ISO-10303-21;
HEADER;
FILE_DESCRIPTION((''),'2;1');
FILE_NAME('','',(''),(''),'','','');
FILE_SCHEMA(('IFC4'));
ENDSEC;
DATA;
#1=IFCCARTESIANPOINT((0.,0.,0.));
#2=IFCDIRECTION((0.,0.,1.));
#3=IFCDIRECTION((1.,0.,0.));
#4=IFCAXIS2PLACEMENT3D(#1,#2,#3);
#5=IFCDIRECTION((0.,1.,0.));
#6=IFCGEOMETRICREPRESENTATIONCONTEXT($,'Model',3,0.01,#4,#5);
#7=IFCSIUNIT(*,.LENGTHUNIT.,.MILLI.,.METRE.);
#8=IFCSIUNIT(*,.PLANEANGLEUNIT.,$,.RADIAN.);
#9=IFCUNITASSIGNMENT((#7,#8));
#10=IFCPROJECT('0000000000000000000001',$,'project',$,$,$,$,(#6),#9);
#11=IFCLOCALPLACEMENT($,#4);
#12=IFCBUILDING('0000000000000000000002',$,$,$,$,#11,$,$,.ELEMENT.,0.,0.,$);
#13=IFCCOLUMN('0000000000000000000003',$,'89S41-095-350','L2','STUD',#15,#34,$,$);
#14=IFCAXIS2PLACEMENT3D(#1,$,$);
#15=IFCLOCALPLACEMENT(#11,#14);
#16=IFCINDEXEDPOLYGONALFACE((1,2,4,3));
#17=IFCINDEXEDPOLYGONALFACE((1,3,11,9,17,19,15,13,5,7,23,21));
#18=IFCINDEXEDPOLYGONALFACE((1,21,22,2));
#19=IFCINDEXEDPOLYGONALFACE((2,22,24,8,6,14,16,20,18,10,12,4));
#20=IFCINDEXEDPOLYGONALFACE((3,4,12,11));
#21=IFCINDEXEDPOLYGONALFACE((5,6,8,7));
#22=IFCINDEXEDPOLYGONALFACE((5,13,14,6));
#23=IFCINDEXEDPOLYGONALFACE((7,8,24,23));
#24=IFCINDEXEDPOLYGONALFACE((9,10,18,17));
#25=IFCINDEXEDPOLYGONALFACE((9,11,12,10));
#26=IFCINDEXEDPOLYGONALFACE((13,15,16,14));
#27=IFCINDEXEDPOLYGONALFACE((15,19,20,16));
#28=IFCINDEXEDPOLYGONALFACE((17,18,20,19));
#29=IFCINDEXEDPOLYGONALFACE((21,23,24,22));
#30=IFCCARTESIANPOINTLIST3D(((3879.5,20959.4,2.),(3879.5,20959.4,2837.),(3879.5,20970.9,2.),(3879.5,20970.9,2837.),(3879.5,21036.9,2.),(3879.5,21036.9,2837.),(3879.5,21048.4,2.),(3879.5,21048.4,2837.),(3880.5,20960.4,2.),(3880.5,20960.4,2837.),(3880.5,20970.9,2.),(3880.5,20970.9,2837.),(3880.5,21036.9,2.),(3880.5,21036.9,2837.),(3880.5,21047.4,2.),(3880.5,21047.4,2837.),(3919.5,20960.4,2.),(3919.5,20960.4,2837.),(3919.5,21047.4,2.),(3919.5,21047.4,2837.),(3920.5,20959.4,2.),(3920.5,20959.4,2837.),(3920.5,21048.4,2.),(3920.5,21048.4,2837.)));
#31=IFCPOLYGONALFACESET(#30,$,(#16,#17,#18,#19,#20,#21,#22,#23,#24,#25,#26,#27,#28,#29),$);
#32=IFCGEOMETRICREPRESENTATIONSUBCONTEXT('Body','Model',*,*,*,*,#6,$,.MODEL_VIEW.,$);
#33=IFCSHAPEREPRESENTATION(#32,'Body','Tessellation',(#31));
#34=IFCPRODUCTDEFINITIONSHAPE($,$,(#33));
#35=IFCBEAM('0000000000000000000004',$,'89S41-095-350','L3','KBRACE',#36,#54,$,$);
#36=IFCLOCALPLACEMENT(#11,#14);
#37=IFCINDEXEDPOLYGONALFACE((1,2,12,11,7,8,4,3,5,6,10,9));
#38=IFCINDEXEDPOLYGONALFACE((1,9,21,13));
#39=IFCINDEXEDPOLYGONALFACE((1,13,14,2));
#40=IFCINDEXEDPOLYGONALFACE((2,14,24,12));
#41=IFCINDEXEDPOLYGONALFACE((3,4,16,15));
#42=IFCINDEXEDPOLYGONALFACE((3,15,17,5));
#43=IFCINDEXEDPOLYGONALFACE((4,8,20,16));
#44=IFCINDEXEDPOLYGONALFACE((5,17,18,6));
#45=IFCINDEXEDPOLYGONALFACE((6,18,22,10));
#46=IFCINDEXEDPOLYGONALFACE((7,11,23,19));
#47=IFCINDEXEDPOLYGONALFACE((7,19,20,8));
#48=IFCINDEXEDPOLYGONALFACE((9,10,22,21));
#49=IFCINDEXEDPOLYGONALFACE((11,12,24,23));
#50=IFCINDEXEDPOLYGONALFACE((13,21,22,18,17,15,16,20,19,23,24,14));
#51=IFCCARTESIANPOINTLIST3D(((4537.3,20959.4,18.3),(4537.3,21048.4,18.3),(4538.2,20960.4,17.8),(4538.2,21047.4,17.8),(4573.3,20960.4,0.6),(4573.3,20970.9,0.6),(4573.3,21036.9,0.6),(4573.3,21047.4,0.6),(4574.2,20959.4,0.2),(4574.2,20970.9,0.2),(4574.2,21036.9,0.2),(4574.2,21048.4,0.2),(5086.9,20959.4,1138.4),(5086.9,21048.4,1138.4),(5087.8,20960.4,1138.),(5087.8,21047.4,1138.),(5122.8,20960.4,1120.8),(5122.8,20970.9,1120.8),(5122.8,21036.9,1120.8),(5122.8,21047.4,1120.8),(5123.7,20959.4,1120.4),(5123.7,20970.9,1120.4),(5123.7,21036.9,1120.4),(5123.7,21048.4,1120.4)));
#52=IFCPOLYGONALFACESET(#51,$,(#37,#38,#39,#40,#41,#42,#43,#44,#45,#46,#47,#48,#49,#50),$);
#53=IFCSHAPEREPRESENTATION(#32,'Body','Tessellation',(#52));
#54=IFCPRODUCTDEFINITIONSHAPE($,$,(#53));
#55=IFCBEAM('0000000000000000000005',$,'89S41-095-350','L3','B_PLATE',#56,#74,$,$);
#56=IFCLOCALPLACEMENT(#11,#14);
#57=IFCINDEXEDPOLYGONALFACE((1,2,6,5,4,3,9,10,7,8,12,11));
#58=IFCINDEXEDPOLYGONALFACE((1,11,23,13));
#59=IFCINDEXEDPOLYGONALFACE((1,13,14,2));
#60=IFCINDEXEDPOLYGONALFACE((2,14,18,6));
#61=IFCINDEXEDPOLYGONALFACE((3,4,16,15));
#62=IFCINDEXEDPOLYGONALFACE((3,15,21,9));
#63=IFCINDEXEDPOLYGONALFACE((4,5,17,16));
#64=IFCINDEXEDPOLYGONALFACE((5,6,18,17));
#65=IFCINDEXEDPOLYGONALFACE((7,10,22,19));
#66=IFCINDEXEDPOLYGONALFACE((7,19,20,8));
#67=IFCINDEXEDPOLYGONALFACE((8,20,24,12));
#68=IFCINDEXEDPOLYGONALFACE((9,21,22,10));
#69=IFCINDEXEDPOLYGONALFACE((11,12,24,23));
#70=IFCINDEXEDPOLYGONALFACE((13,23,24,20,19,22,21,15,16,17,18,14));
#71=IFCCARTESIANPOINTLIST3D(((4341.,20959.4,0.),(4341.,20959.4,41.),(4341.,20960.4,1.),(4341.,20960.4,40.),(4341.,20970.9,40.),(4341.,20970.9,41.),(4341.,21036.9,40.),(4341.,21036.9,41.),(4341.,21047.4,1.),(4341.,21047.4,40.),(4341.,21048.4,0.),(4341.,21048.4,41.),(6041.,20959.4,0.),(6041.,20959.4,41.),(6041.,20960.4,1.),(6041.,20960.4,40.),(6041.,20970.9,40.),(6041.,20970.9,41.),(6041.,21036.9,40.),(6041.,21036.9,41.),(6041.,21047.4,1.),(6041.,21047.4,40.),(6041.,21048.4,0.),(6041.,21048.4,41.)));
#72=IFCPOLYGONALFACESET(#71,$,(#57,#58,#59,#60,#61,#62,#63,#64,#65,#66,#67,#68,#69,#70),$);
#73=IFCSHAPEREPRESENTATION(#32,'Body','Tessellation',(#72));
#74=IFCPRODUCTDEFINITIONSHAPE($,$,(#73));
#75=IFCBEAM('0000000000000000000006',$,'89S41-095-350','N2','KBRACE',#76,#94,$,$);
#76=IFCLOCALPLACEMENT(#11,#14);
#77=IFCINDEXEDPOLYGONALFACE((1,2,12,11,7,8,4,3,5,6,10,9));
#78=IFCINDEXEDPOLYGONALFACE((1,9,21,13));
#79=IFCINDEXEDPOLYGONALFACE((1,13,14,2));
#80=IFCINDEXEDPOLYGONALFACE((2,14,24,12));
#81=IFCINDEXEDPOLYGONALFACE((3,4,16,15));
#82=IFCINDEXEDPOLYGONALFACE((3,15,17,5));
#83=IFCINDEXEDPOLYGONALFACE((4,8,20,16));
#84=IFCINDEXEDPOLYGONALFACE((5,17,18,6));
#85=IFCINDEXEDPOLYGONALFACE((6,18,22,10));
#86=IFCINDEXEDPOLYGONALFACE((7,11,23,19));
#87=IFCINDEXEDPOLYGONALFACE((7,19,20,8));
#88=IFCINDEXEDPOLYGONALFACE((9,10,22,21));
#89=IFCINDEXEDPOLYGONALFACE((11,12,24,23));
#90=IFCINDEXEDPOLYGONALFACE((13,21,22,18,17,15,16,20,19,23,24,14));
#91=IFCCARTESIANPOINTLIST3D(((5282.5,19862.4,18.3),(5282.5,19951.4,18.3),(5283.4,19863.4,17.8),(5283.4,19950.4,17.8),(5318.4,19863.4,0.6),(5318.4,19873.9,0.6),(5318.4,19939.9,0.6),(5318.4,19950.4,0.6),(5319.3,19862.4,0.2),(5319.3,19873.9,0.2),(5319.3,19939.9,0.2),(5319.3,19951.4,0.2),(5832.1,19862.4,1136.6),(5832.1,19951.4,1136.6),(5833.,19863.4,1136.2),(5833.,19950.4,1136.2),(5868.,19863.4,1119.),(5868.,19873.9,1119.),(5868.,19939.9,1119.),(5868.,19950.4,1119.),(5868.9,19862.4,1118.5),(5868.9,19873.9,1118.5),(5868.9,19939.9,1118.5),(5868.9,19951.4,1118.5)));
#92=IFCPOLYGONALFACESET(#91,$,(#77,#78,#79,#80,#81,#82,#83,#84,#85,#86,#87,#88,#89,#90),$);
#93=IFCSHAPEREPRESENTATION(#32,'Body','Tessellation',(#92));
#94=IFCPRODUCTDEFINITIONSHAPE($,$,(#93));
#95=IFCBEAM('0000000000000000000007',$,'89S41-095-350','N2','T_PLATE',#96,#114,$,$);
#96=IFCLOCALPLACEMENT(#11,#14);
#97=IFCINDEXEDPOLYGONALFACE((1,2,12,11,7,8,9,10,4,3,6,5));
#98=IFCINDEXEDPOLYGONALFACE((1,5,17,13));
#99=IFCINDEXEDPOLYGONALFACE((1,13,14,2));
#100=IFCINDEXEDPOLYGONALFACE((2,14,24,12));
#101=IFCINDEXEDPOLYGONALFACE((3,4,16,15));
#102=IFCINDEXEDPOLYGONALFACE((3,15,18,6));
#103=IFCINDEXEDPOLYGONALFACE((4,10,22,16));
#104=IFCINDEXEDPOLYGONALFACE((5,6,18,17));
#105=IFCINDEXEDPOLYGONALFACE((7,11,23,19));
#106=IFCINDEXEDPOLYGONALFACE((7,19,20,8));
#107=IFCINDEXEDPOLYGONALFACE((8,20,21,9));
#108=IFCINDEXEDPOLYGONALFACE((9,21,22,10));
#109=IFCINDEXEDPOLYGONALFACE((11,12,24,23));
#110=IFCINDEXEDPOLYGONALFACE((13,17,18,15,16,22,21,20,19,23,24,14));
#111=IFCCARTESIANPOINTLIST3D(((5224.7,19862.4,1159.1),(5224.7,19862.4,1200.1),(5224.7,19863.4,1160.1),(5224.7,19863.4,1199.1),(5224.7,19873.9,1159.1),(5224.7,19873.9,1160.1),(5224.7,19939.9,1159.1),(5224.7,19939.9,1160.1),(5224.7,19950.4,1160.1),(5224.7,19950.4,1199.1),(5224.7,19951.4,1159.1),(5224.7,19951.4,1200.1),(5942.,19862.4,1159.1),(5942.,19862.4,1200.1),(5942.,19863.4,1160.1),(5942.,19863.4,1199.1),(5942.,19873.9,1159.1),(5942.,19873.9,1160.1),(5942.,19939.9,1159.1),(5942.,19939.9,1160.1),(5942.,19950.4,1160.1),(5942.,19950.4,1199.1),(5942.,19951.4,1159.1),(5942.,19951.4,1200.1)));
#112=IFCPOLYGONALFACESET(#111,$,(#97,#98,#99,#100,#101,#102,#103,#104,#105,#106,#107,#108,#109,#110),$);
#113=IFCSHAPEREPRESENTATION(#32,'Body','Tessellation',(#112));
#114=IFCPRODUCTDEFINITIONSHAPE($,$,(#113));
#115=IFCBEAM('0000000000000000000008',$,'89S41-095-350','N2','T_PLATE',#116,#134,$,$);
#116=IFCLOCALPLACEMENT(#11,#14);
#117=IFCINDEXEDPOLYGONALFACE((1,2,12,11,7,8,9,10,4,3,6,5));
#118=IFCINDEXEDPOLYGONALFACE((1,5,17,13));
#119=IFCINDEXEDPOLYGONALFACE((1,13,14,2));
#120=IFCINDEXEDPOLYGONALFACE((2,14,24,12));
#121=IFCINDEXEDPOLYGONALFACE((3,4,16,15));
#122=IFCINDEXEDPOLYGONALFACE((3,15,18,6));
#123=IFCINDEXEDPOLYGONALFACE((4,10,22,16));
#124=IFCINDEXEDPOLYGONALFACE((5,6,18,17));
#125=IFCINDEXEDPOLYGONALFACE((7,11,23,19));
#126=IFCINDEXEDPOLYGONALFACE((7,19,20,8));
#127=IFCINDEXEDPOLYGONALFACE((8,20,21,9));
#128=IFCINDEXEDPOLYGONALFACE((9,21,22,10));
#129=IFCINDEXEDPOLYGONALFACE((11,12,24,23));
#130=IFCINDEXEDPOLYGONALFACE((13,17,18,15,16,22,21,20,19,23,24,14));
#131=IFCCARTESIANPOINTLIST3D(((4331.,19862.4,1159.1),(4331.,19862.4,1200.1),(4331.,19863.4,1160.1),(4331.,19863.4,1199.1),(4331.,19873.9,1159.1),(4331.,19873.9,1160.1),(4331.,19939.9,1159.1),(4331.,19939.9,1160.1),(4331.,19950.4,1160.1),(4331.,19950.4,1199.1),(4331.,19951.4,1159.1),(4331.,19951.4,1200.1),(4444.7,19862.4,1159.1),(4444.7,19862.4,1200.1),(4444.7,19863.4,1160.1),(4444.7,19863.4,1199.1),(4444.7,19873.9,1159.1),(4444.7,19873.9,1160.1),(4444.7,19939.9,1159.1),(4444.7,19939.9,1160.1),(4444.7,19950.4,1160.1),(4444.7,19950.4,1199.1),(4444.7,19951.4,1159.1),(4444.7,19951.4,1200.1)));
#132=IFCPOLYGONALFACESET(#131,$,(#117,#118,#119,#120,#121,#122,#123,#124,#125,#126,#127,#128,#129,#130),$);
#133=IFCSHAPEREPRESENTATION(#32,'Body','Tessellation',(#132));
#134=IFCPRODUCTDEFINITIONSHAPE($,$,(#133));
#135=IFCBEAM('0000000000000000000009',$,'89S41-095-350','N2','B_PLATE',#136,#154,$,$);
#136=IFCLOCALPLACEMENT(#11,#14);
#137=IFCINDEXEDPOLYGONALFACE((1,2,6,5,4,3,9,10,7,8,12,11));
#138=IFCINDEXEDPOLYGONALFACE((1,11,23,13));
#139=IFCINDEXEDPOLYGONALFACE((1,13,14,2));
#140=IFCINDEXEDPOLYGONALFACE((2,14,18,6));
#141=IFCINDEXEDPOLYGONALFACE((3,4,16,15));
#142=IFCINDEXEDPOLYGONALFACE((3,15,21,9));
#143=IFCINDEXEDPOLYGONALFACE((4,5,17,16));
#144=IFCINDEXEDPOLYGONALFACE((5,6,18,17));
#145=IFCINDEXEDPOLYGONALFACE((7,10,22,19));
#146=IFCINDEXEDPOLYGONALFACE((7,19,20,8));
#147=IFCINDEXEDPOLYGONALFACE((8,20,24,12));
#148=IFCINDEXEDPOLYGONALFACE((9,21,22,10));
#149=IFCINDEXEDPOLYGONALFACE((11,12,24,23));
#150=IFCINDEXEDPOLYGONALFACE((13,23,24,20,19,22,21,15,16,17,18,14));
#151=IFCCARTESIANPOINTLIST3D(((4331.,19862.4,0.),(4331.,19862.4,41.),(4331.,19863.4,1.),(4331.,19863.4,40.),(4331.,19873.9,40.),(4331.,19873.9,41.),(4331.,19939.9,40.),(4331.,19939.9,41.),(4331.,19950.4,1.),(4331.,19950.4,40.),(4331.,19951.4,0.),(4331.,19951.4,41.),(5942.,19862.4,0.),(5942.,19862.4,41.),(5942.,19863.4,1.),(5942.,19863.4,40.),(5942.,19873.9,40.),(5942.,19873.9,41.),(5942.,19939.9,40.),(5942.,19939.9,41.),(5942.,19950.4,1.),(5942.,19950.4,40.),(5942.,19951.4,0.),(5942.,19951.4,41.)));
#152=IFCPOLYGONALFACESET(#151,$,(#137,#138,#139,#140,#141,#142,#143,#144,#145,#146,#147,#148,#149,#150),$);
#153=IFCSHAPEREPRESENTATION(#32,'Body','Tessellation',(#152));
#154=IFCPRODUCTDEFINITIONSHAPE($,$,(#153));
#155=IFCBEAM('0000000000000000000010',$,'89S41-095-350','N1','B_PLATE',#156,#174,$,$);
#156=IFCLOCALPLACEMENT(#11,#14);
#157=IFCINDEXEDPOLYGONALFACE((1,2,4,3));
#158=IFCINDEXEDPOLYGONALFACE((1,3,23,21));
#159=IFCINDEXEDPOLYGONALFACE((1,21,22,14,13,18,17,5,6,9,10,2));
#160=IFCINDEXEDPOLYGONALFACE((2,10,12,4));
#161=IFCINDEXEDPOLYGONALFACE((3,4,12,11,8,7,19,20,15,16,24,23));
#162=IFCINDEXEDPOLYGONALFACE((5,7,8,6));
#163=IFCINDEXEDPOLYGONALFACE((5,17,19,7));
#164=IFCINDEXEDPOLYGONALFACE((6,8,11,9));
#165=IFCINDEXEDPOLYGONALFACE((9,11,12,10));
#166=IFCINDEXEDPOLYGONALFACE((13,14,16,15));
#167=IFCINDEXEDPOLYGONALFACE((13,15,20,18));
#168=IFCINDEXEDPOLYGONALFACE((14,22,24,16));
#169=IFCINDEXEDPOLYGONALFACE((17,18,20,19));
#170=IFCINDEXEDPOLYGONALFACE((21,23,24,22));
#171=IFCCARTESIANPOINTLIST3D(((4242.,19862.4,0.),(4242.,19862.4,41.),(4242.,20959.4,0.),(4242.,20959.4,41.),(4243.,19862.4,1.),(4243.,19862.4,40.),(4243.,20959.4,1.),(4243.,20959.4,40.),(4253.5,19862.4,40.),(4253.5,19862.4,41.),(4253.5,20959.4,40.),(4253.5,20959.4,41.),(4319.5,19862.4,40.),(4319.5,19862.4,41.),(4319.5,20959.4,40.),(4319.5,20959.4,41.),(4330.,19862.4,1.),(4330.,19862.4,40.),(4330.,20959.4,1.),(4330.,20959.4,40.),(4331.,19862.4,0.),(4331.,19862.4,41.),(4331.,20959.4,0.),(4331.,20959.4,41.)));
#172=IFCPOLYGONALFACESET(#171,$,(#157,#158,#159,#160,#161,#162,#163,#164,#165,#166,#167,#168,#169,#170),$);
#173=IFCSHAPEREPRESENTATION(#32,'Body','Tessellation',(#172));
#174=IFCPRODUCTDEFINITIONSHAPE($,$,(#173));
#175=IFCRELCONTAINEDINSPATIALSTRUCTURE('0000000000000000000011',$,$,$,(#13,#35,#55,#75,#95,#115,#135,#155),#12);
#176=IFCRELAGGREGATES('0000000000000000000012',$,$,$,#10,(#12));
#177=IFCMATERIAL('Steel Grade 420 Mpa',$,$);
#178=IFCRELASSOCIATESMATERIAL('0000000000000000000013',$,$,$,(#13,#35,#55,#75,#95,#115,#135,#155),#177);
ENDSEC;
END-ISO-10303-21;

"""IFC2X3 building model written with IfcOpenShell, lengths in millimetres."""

from ifc_helpers import new_model, si_unit, direction, frame, origin, origin_with_axes, origin_2d_with_axis, place, context, subcontext, project, spatial, c_section, extrude, source, transform, mapped, material, element, save


model = new_model("IFC2X3")

# Units and contexts
model_context = context("Model", 3, precision=0.01, world=origin_with_axes(), true_north=direction((0.0, 1.0, 0.0)))
body_context = subcontext(model_context, "Body", "Model", "MODEL_VIEW")
ifc_project = project(units=[si_unit("LENGTHUNIT", "METRE", prefix="MILLI"), si_unit("PLANEANGLEUNIT", "RADIAN")], contexts=[model_context])

# Building
building_placement = place(None, origin_with_axes())
building = spatial("IfcBuilding", under=ifc_project, at=building_placement, CompositionType="ELEMENT", ElevationOfRefHeight=0.0, ElevationOfTerrain=0.0)

# Column
ifc_material = material(Name="Steel Grade 420 Mpa")
shared_shape_1 = source(origin(), body_context, "Body", "SweptSolid", [
    extrude(c_section(Depth=89.0, Width=41.0, WallThickness=1.0, Girth=11.5, at=origin_2d_with_axis()), origin_with_axes(), (0.0, 0.0, 1.0), 2835.0),
])
column_1_placement = place(None, frame((3900.0, 21003.9, 2.0), z_axis=(0.0, 0.0, 1.0), x_axis=(-1.0, 0.0, 0.0)))
element("IfcColumn", 1, at=column_1_placement, inside=building, material=ifc_material, Name="89S41-095-350", Description="L2", ObjectType="STUD", context=body_context, shape_type="MappedRepresentation", body=[
    mapped(shared_shape_1, transform((0.0, 0.0, 0.0), scale=1.0)),
])

# Beams
shared_shape_2 = source(origin(), body_context, "Body", "SweptSolid", [
    extrude(c_section(Depth=89.0, Width=41.0, WallThickness=1.0, Girth=11.5, at=origin_2d_with_axis()), origin_with_axes(), (0.0, 0.0, 1.0), 1247.7),
])
beam_1_placement = place(None, frame((4555.7, 21003.9, 9.2), z_axis=(0.440455, 0.0, 0.897774), x_axis=(0.897774, 0.0, -0.440455)))
element("IfcBeam", 2, at=beam_1_placement, inside=building, material=ifc_material, Name="89S41-095-350", Description="L3", ObjectType="KBRACE", context=body_context, shape_type="MappedRepresentation", body=[
    mapped(shared_shape_2, transform((0.0, 0.0, 0.0), scale=1.0)),
])
shared_shape_3 = source(origin(), body_context, "Body", "SweptSolid", [
    extrude(c_section(Depth=89.0, Width=41.0, WallThickness=1.0, Girth=11.5, at=origin_2d_with_axis()), origin_with_axes(), (0.0, 0.0, 1.0), 1700.0),
])
beam_2_placement = place(None, frame((4341.0, 21003.9, 20.5), z_axis=(1.0, 0.0, 0.0), x_axis=(0.0, 0.0, 1.0)))
element("IfcBeam", 3, at=beam_2_placement, inside=building, material=ifc_material, Name="89S41-095-350", Description="L3", ObjectType="B_PLATE", context=body_context, shape_type="MappedRepresentation", body=[
    mapped(shared_shape_3, transform((0.0, 0.0, 0.0), scale=1.0)),
])
shared_shape_4 = source(origin(), body_context, "Body", "SweptSolid", [
    extrude(c_section(Depth=89.0, Width=41.0, WallThickness=1.0, Girth=11.5, at=origin_2d_with_axis()), origin_with_axes(), (0.0, 0.0, 1.0), 1246.1),
])
beam_3_placement = place(None, frame((5300.9, 19906.9, 9.2), z_axis=(0.441044, 0.0, 0.897485), x_axis=(0.897485, 0.0, -0.441044)))
element("IfcBeam", 4, at=beam_3_placement, inside=building, material=ifc_material, Name="89S41-095-350", Description="N2", ObjectType="KBRACE", context=body_context, shape_type="MappedRepresentation", body=[
    mapped(shared_shape_4, transform((0.0, 0.0, 0.0), scale=1.0)),
])
shared_shape_5 = source(origin(), body_context, "Body", "SweptSolid", [
    extrude(c_section(Depth=89.0, Width=41.0, WallThickness=1.0, Girth=11.5, at=origin_2d_with_axis()), origin_with_axes(), (0.0, 0.0, 1.0), 717.3),
])
beam_4_placement = place(None, frame((5224.7, 19906.9, 1179.6), z_axis=(1.0, 0.0, 0.0), x_axis=(0.0, 0.0, -1.0)))
element("IfcBeam", 5, at=beam_4_placement, inside=building, material=ifc_material, Name="89S41-095-350", Description="N2", ObjectType="T_PLATE", context=body_context, shape_type="MappedRepresentation", body=[
    mapped(shared_shape_5, transform((0.0, 0.0, 0.0), scale=1.0)),
])
shared_shape_6 = source(origin(), body_context, "Body", "SweptSolid", [
    extrude(c_section(Depth=89.0, Width=41.0, WallThickness=1.0, Girth=11.5, at=origin_2d_with_axis()), origin_with_axes(), (0.0, 0.0, 1.0), 113.7),
])
beam_5_placement = place(None, frame((4331.0, 19906.9, 1179.6), z_axis=(1.0, 0.0, 0.0), x_axis=(0.0, 0.0, -1.0)))
element("IfcBeam", 6, at=beam_5_placement, inside=building, material=ifc_material, Name="89S41-095-350", Description="N2", ObjectType="T_PLATE", context=body_context, shape_type="MappedRepresentation", body=[
    mapped(shared_shape_6, transform((0.0, 0.0, 0.0), scale=1.0)),
])
shared_shape_7 = source(origin(), body_context, "Body", "SweptSolid", [
    extrude(c_section(Depth=89.0, Width=41.0, WallThickness=1.0, Girth=11.5, at=origin_2d_with_axis()), origin_with_axes(), (0.0, 0.0, 1.0), 1611.0),
])
beam_6_placement = place(None, frame((4331.0, 19906.9, 20.5), z_axis=(1.0, 0.0, 0.0), x_axis=(0.0, 0.0, 1.0)))
element("IfcBeam", 7, at=beam_6_placement, inside=building, material=ifc_material, Name="89S41-095-350", Description="N2", ObjectType="B_PLATE", context=body_context, shape_type="MappedRepresentation", body=[
    mapped(shared_shape_7, transform((0.0, 0.0, 0.0), scale=1.0)),
])
shared_shape_8 = source(origin(), body_context, "Body", "SweptSolid", [
    extrude(c_section(Depth=89.0, Width=41.0, WallThickness=1.0, Girth=11.5, at=origin_2d_with_axis()), origin_with_axes(), (0.0, 0.0, 1.0), 1097.0),
])
beam_7_placement = place(None, frame((4286.5, 20959.4, 20.5), z_axis=(0.0, -1.0, 0.0), x_axis=(0.0, 0.0, 1.0)))
element("IfcBeam", 8, at=beam_7_placement, inside=building, material=ifc_material, Name="89S41-095-350", Description="N1", ObjectType="B_PLATE", context=body_context, shape_type="MappedRepresentation", body=[
    mapped(shared_shape_8, transform((0.0, 0.0, 0.0), scale=1.0)),
])

save(model, "model.ifc")
